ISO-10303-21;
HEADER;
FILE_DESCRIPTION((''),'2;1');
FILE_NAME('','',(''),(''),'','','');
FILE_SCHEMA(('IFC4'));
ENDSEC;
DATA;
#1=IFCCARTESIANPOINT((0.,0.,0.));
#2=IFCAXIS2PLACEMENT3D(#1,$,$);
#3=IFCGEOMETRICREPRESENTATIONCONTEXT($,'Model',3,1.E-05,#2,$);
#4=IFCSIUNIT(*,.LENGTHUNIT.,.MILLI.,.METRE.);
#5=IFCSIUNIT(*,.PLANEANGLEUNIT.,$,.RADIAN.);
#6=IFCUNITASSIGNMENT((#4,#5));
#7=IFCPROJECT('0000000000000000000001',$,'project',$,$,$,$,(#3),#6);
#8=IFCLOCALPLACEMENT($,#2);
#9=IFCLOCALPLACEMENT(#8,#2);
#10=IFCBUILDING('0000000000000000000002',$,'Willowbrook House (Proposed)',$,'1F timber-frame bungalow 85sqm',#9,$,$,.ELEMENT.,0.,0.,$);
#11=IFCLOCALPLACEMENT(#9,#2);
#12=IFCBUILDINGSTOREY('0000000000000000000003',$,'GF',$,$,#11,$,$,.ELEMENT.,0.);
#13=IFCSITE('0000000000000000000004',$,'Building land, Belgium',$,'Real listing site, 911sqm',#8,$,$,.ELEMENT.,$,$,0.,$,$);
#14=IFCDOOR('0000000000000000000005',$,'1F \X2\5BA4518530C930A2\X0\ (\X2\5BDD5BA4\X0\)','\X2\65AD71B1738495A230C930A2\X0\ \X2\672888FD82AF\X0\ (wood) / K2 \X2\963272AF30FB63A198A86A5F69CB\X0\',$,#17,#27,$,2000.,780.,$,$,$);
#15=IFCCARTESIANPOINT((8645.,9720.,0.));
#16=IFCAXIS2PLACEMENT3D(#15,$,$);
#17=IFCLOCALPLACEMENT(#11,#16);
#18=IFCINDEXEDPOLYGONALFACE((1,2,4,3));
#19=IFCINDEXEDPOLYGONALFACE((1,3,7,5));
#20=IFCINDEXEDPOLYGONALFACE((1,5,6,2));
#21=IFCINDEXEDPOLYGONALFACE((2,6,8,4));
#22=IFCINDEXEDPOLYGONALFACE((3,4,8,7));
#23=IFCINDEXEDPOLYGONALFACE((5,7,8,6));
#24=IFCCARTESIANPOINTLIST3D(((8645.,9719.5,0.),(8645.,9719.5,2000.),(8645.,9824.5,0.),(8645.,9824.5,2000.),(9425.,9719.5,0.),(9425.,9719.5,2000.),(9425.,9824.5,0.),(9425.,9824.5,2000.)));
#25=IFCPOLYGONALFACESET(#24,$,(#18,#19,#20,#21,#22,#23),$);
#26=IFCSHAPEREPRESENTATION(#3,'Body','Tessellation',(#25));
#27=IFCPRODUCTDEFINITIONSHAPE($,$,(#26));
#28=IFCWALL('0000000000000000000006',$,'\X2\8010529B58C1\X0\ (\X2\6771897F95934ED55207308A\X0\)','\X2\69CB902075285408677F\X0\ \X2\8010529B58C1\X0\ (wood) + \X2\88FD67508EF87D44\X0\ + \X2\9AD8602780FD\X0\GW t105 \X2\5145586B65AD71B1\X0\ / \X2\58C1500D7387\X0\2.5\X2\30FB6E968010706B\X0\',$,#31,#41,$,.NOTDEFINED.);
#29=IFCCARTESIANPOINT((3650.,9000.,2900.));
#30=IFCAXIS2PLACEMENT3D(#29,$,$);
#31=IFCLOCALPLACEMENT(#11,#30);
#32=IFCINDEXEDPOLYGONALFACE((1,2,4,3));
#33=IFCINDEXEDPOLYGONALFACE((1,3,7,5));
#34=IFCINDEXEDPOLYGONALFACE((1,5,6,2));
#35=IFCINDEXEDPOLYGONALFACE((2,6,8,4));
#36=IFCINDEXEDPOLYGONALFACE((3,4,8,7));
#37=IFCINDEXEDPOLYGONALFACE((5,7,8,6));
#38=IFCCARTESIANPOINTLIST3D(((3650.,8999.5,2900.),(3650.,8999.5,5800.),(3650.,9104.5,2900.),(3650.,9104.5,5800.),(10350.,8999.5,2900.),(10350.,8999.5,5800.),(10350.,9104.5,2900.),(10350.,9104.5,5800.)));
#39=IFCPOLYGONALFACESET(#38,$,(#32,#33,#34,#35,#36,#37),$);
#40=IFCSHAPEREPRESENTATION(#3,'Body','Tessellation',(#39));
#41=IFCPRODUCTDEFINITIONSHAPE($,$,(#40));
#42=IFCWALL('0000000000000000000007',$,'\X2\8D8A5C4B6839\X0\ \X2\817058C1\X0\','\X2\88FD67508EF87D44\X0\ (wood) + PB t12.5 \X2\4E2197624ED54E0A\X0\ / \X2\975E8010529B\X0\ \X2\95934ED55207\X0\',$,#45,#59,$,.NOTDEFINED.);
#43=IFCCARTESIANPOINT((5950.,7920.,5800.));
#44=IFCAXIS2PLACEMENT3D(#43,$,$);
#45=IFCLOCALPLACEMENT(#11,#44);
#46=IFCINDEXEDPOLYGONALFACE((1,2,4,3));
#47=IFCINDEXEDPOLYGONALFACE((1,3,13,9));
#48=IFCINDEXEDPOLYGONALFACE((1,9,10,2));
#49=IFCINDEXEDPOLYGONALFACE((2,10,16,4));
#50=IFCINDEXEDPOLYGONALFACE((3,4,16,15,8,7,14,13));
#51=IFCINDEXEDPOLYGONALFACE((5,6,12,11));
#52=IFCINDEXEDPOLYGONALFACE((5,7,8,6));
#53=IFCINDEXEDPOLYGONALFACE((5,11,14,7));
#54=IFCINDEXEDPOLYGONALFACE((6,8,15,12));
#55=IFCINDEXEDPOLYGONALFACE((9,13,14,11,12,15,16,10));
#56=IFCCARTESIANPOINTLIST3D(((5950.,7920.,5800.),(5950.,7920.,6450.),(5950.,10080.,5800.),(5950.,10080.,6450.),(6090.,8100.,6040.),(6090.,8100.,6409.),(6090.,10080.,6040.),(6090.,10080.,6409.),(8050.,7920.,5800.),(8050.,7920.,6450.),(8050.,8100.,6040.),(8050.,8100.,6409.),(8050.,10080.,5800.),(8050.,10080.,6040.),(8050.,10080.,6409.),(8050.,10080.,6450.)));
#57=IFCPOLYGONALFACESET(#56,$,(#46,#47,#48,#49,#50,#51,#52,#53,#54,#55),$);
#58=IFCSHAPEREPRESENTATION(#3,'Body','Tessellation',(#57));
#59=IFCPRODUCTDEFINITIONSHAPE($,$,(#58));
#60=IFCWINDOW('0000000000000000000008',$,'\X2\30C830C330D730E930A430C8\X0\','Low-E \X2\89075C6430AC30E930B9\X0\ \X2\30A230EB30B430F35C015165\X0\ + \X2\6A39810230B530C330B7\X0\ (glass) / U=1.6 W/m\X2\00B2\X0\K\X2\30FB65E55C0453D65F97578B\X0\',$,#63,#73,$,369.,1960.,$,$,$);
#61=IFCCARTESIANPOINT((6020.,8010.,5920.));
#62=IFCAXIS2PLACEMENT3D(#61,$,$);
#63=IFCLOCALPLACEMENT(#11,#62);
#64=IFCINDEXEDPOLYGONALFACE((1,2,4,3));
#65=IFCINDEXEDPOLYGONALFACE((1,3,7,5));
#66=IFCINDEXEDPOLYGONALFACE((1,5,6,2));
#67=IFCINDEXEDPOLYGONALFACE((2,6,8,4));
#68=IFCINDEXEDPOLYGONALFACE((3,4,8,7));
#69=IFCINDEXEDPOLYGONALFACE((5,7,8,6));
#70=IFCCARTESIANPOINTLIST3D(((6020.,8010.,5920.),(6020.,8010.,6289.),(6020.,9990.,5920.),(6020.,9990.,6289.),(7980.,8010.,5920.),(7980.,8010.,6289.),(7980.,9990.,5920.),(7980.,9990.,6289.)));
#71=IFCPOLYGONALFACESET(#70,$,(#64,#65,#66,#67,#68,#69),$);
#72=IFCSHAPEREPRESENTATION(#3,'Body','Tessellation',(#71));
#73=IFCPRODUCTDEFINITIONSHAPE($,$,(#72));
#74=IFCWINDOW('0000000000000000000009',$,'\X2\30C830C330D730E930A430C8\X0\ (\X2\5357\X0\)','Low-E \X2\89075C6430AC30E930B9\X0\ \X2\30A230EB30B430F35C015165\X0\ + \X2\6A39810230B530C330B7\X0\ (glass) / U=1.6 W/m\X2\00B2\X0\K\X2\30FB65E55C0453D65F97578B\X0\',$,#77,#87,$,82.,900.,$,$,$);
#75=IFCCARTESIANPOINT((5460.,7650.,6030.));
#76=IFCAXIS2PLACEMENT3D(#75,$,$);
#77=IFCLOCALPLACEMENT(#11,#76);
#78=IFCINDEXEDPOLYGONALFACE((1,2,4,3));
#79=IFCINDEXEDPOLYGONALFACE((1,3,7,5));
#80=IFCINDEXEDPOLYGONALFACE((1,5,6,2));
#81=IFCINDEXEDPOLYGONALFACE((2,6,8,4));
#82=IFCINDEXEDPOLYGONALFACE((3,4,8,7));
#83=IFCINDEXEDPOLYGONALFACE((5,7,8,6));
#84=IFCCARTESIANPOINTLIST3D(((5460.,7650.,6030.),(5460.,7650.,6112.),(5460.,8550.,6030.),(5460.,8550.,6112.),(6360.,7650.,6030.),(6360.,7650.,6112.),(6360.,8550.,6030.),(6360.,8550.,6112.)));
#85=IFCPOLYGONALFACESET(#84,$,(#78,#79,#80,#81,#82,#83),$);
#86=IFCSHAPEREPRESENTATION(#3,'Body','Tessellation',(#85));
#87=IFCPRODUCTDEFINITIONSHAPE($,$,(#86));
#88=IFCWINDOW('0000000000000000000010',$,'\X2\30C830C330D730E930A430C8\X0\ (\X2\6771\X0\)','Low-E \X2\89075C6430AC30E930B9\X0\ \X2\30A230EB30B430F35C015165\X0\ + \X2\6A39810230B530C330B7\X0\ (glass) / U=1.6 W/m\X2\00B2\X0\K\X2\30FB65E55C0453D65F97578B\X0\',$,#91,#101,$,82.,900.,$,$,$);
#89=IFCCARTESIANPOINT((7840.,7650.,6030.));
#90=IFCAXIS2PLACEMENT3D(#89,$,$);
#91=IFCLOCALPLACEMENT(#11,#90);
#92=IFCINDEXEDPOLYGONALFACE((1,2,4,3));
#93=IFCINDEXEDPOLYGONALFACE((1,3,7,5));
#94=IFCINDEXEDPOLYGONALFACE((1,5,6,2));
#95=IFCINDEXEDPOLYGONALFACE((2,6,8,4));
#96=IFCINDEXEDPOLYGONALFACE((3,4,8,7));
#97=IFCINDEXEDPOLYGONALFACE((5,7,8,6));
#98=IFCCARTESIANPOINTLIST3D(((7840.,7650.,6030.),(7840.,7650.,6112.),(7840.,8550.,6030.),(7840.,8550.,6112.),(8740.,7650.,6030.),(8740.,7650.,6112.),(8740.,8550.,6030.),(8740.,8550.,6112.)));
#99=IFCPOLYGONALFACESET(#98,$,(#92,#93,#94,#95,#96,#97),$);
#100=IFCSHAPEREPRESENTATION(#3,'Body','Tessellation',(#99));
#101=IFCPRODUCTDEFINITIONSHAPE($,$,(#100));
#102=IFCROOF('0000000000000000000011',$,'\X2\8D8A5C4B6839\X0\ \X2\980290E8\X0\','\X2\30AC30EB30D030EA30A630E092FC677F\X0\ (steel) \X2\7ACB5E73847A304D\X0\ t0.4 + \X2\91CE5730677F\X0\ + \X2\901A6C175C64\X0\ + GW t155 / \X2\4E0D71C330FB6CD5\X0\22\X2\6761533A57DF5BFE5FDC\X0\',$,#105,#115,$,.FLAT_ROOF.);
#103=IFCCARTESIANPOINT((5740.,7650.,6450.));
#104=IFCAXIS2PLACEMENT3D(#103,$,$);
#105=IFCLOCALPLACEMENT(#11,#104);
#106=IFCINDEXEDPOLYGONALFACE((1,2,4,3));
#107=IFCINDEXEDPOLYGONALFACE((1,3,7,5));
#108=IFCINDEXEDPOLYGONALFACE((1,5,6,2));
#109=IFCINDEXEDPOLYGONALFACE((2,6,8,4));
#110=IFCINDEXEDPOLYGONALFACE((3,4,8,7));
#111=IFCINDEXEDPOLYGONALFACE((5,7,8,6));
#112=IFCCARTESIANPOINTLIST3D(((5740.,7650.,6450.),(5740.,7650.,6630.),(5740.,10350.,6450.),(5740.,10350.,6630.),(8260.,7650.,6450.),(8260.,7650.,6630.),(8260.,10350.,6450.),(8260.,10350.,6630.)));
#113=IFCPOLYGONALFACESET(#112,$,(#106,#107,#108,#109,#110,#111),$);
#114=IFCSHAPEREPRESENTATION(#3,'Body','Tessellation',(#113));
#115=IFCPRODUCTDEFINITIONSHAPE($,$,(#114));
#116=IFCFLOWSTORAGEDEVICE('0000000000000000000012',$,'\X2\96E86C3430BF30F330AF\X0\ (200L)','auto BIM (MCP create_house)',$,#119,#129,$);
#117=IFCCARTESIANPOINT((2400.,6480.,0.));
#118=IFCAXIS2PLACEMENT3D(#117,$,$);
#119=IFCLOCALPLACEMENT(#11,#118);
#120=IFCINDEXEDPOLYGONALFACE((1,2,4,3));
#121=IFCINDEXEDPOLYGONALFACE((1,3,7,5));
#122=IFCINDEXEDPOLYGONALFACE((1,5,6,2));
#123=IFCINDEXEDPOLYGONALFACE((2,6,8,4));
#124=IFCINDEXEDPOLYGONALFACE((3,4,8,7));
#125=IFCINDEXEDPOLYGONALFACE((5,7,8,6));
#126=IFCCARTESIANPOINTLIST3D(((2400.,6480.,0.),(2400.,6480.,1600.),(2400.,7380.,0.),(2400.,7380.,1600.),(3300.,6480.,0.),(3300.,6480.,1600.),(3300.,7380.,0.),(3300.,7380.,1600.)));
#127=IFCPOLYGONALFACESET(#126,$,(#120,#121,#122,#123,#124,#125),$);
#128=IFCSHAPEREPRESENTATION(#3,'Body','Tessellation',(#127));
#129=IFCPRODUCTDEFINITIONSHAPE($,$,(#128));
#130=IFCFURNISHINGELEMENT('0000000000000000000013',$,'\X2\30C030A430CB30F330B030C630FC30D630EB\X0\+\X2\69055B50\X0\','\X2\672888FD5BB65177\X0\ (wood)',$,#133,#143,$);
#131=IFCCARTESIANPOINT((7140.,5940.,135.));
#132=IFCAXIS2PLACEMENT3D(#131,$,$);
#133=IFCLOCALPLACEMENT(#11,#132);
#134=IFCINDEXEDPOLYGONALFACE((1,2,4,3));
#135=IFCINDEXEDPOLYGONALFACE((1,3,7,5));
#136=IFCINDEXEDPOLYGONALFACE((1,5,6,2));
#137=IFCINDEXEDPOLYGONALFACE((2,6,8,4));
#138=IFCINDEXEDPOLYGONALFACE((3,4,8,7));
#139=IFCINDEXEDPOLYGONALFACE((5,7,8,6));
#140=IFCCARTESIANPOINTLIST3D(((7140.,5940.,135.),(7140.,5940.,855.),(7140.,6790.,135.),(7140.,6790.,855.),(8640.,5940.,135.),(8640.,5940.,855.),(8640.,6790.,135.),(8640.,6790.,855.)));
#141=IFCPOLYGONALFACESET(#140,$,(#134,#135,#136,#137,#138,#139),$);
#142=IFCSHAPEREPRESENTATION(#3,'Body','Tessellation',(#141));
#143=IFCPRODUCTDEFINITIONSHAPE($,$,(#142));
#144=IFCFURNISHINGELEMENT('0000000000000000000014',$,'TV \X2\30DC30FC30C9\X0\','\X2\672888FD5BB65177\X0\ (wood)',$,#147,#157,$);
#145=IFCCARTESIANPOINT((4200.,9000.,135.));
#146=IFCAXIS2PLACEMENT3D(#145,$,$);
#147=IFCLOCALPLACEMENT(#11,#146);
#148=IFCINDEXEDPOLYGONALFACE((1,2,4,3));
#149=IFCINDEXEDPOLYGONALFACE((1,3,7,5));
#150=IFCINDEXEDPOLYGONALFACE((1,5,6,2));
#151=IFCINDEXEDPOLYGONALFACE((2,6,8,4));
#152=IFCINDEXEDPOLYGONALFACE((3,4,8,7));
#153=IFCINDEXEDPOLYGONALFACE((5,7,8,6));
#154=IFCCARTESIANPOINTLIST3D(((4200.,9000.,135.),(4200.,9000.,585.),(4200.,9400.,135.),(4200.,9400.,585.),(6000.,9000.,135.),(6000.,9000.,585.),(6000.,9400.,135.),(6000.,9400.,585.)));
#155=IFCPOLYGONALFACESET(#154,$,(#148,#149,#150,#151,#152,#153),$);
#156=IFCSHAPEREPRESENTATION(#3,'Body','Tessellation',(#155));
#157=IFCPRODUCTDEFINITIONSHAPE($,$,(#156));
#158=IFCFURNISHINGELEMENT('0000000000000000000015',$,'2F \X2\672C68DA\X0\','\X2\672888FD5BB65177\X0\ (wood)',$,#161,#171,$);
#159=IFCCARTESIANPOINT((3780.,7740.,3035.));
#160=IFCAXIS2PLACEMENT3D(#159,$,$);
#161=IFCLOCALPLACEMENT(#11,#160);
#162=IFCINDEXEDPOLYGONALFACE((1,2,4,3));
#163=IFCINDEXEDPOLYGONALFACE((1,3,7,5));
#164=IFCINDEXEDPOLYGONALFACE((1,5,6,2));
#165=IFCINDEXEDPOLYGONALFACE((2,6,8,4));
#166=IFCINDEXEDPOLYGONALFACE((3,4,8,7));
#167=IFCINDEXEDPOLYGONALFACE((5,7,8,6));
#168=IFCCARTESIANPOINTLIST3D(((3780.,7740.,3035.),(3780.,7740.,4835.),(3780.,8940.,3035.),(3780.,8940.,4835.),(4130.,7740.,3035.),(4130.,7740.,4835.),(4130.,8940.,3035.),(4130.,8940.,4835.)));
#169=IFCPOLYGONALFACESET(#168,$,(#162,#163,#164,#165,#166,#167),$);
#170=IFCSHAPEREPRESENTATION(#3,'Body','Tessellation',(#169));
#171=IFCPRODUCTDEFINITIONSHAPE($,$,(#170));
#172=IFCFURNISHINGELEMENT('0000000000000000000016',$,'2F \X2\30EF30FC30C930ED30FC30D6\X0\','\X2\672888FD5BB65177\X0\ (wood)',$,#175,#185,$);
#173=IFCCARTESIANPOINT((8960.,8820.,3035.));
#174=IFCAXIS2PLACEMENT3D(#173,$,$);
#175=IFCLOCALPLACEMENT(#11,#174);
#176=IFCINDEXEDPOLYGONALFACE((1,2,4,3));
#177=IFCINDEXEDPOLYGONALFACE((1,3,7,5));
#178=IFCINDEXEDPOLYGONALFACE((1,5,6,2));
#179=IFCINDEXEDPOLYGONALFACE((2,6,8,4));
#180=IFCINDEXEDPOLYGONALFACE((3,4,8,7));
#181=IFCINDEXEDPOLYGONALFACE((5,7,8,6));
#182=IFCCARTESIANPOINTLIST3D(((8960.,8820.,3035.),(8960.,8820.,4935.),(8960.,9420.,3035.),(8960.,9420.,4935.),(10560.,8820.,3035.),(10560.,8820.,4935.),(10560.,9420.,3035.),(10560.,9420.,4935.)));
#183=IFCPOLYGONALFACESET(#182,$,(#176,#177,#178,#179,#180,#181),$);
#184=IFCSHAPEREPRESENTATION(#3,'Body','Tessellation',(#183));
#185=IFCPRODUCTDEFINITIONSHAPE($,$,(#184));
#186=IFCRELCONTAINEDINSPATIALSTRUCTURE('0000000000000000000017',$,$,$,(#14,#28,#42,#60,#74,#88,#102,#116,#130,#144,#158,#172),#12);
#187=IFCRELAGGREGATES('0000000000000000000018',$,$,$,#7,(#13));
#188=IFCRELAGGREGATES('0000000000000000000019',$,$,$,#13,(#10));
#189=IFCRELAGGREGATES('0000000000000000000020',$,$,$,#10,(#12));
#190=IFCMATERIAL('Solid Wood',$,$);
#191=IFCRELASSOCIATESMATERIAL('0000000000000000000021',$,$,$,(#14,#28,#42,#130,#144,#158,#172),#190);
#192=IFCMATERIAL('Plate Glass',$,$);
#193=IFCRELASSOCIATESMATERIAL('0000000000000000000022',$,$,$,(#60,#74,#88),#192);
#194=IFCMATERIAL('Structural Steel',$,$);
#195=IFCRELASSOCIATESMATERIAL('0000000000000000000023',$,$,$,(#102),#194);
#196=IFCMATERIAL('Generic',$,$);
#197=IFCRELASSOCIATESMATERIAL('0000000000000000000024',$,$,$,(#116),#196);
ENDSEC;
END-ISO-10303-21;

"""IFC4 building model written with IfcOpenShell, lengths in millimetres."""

from ifc_helpers import new_model, si_unit, frame, frame_2d, origin, place, context, project, spatial, rectangle, extrude, material, element, fill, save


model = new_model("IFC4")

# Units and contexts
model_context = context("Model", 3, precision=1e-05, world=origin())
ifc_project = project(units=[si_unit("LENGTHUNIT", "METRE", prefix="MILLI"), si_unit("PLANEANGLEUNIT", "RADIAN")], contexts=[model_context])

# Site, building, storey
site_placement = place(None, origin())
site = spatial("IfcSite", under=ifc_project, at=site_placement, Name="Building land, Belgium", ObjectType="Real listing site, 911sqm", CompositionType="ELEMENT", RefElevation=0.0)
building_placement = place(site_placement, origin())
building = spatial("IfcBuilding", under=site, at=building_placement, Name="Willowbrook House (Proposed)", ObjectType="1F timber-frame bungalow 85sqm", CompositionType="ELEMENT", ElevationOfRefHeight=0.0, ElevationOfTerrain=0.0)
storey_placement = place(building_placement, origin())
storey = spatial("IfcBuildingStorey", under=building, at=storey_placement, Name="GF", CompositionType="ELEMENT", Elevation=0.0)

# Shared definitions
ifc_material_1 = material(Name="Solid Wood")

# Door
door_placement = place(storey_placement, frame((8645.0, 9720.0, 0.0)))
element("IfcDoor", 1, at=door_placement, inside=storey, material=ifc_material_1, Name="1F 室内ドア (寝室)", Description="断熱玄関ドア 木製芯 (wood) / K2 防犯・採風機構", OverallHeight=2000.0, OverallWidth=780.0, context=model_context, shape_type="SweptSolid", body=[
    extrude(rectangle(XDim=780.0, YDim=105.0, at=frame_2d((390.0, 52.0))), frame((8645.0, 9720.0, 0.0)), (0.0, 0.0, 1.0), 2000.0),
])

# Wall
wall_1_placement = place(storey_placement, frame((3650.0, 9000.0, 2900.0)))
element("IfcWall", 2, at=wall_1_placement, inside=storey, material=ifc_material_1, Name="耐力壁 (東西間仕切り)", Description="構造用合板 耐力壁 (wood) + 製材軸組 + 高性能GW t105 充填断熱 / 壁倍率2.5・準耐火", PredefinedType="NOTDEFINED", context=model_context, shape_type="SweptSolid", body=[
    extrude(rectangle(XDim=6700.0, YDim=105.0, at=frame_2d((3350.0, 52.0))), frame((3650.0, 9000.0, 2900.0)), (0.0, 0.0, 1.0), 2900.0),
])

# Wall, openings, windows
wall_2_placement = place(storey_placement, frame((5950.0, 7920.0, 5800.0)))
wall_2 = element("IfcWall", 3, at=wall_2_placement, inside=storey, material=ifc_material_1, Name="越屋根 腰壁", Description="製材軸組 (wood) + PB t12.5 両面仕上 / 非耐力 間仕切", PredefinedType="NOTDEFINED", context=model_context, shape_type="SweptSolid", body=[
    extrude(rectangle(XDim=2100.0, YDim=2160.0, at=frame_2d((1050.0, 1080.0))), frame((5950.0, 7920.0, 5800.0)), (0.0, 0.0, 1.0), 650.0),
])
opening_1_placement = place(storey_placement, frame((6020.0, 8010.0, 5920.0)))
opening_1 = element("IfcOpeningElement", 4, at=opening_1_placement, cuts=wall_2, PredefinedType="NOTDEFINED", context=model_context, shape_type="SweptSolid", body=[
    extrude(rectangle(XDim=1960.0, YDim=1980.0, at=frame_2d((980.0, 990.0))), frame((6020.0, 8010.0, 5920.0)), (0.0, 0.0, 1.0), 369.0),
])
opening_2_placement = place(storey_placement, frame((5460.0, 7650.0, 6030.0)))
opening_2 = element("IfcOpeningElement", 5, at=opening_2_placement, cuts=wall_2, PredefinedType="NOTDEFINED", context=model_context, shape_type="SweptSolid", body=[
    extrude(rectangle(XDim=900.0, YDim=900.0, at=frame_2d((450.0, 450.0))), frame((5460.0, 7650.0, 6030.0)), (0.0, 0.0, 1.0), 82.0),
])
opening_3_placement = place(storey_placement, frame((7840.0, 7650.0, 6030.0)))
opening_3 = element("IfcOpeningElement", 6, at=opening_3_placement, cuts=wall_2, PredefinedType="NOTDEFINED", context=model_context, shape_type="SweptSolid", body=[
    extrude(rectangle(XDim=900.0, YDim=900.0, at=frame_2d((450.0, 450.0))), frame((7840.0, 7650.0, 6030.0)), (0.0, 0.0, 1.0), 82.0),
])
ifc_material_2 = material(Name="Plate Glass")
window_1_placement = place(storey_placement, frame((6020.0, 8010.0, 5920.0)))
window_1 = element("IfcWindow", 7, at=window_1_placement, inside=storey, material=ifc_material_2, Name="トップライト", Description="Low-E 複層ガラス アルゴン封入 + 樹脂サッシ (glass) / U=1.6 W/m²K・日射取得型", OverallHeight=369.0, OverallWidth=1960.0, context=model_context, shape_type="SweptSolid", body=[
    extrude(rectangle(XDim=1960.0, YDim=1980.0, at=frame_2d((980.0, 990.0))), frame((6020.0, 8010.0, 5920.0)), (0.0, 0.0, 1.0), 369.0),
])
fill(opening_1, window_1)
window_2_placement = place(storey_placement, frame((5460.0, 7650.0, 6030.0)))
window_2 = element("IfcWindow", 8, at=window_2_placement, inside=storey, material=ifc_material_2, Name="トップライト (南)", Description="Low-E 複層ガラス アルゴン封入 + 樹脂サッシ (glass) / U=1.6 W/m²K・日射取得型", OverallHeight=82.0, OverallWidth=900.0, context=model_context, shape_type="SweptSolid", body=[
    extrude(rectangle(XDim=900.0, YDim=900.0, at=frame_2d((450.0, 450.0))), frame((5460.0, 7650.0, 6030.0)), (0.0, 0.0, 1.0), 82.0),
])
fill(opening_2, window_2)
window_3_placement = place(storey_placement, frame((7840.0, 7650.0, 6030.0)))
window_3 = element("IfcWindow", 9, at=window_3_placement, inside=storey, material=ifc_material_2, Name="トップライト (東)", Description="Low-E 複層ガラス アルゴン封入 + 樹脂サッシ (glass) / U=1.6 W/m²K・日射取得型", OverallHeight=82.0, OverallWidth=900.0, context=model_context, shape_type="SweptSolid", body=[
    extrude(rectangle(XDim=900.0, YDim=900.0, at=frame_2d((450.0, 450.0))), frame((7840.0, 7650.0, 6030.0)), (0.0, 0.0, 1.0), 82.0),
])
fill(opening_3, window_3)

# Roof
ifc_material_3 = material(Name="Structural Steel")
roof_placement = place(storey_placement, frame((5740.0, 7650.0, 6450.0)))
element("IfcRoof", 10, at=roof_placement, inside=storey, material=ifc_material_3, Name="越屋根 頂部", Description="ガルバリウム鋼板 (steel) 立平葺き t0.4 + 野地板 + 通気層 + GW t155 / 不燃・法22条区域対応", PredefinedType="FLAT_ROOF", context=model_context, shape_type="SweptSolid", body=[
    extrude(rectangle(XDim=2520.0, YDim=2700.0, at=frame_2d((1260.0, 1350.0))), frame((5740.0, 7650.0, 6450.0)), (0.0, 0.0, 1.0), 180.0),
])

# Flow storage device
ifc_material_4 = material(Name="Generic")
flow_storage_device_placement = place(storey_placement, frame((2400.0, 6480.0, 0.0)))
element("IfcFlowStorageDevice", 11, at=flow_storage_device_placement, inside=storey, material=ifc_material_4, Name="雨水タンク (200L)", Description="auto BIM (MCP create_house)", context=model_context, shape_type="SweptSolid", body=[
    extrude(rectangle(XDim=900.0, YDim=900.0, at=frame_2d((450.0, 450.0))), frame((2400.0, 6480.0, 0.0)), (0.0, 0.0, 1.0), 1600.0),
])

# Furnishing elements
furnishing_1_placement = place(storey_placement, frame((7140.0, 5940.0, 135.0)))
element("IfcFurnishingElement", 12, at=furnishing_1_placement, inside=storey, material=ifc_material_1, Name="ダイニングテーブル+椅子", Description="木製家具 (wood)", context=model_context, shape_type="SweptSolid", body=[
    extrude(rectangle(XDim=1500.0, YDim=850.0, at=frame_2d((750.0, 425.0))), frame((7140.0, 5940.0, 135.0)), (0.0, 0.0, 1.0), 720.0),
])
furnishing_2_placement = place(storey_placement, frame((4200.0, 9000.0, 135.0)))
element("IfcFurnishingElement", 13, at=furnishing_2_placement, inside=storey, material=ifc_material_1, Name="TV ボード", Description="木製家具 (wood)", context=model_context, shape_type="SweptSolid", body=[
    extrude(rectangle(XDim=1800.0, YDim=400.0, at=frame_2d((900.0, 200.0))), frame((4200.0, 9000.0, 135.0)), (0.0, 0.0, 1.0), 450.0),
])
furnishing_3_placement = place(storey_placement, frame((3780.0, 7740.0, 3035.0)))
element("IfcFurnishingElement", 14, at=furnishing_3_placement, inside=storey, material=ifc_material_1, Name="2F 本棚", Description="木製家具 (wood)", context=model_context, shape_type="SweptSolid", body=[
    extrude(rectangle(XDim=350.0, YDim=1200.0, at=frame_2d((175.0, 600.0))), frame((3780.0, 7740.0, 3035.0)), (0.0, 0.0, 1.0), 1800.0),
])
furnishing_4_placement = place(storey_placement, frame((8960.0, 8820.0, 3035.0)))
element("IfcFurnishingElement", 15, at=furnishing_4_placement, inside=storey, material=ifc_material_1, Name="2F ワードローブ", Description="木製家具 (wood)", context=model_context, shape_type="SweptSolid", body=[
    extrude(rectangle(XDim=1600.0, YDim=600.0, at=frame_2d((800.0, 300.0))), frame((8960.0, 8820.0, 3035.0)), (0.0, 0.0, 1.0), 1900.0),
])

save(model, "model.ifc")
